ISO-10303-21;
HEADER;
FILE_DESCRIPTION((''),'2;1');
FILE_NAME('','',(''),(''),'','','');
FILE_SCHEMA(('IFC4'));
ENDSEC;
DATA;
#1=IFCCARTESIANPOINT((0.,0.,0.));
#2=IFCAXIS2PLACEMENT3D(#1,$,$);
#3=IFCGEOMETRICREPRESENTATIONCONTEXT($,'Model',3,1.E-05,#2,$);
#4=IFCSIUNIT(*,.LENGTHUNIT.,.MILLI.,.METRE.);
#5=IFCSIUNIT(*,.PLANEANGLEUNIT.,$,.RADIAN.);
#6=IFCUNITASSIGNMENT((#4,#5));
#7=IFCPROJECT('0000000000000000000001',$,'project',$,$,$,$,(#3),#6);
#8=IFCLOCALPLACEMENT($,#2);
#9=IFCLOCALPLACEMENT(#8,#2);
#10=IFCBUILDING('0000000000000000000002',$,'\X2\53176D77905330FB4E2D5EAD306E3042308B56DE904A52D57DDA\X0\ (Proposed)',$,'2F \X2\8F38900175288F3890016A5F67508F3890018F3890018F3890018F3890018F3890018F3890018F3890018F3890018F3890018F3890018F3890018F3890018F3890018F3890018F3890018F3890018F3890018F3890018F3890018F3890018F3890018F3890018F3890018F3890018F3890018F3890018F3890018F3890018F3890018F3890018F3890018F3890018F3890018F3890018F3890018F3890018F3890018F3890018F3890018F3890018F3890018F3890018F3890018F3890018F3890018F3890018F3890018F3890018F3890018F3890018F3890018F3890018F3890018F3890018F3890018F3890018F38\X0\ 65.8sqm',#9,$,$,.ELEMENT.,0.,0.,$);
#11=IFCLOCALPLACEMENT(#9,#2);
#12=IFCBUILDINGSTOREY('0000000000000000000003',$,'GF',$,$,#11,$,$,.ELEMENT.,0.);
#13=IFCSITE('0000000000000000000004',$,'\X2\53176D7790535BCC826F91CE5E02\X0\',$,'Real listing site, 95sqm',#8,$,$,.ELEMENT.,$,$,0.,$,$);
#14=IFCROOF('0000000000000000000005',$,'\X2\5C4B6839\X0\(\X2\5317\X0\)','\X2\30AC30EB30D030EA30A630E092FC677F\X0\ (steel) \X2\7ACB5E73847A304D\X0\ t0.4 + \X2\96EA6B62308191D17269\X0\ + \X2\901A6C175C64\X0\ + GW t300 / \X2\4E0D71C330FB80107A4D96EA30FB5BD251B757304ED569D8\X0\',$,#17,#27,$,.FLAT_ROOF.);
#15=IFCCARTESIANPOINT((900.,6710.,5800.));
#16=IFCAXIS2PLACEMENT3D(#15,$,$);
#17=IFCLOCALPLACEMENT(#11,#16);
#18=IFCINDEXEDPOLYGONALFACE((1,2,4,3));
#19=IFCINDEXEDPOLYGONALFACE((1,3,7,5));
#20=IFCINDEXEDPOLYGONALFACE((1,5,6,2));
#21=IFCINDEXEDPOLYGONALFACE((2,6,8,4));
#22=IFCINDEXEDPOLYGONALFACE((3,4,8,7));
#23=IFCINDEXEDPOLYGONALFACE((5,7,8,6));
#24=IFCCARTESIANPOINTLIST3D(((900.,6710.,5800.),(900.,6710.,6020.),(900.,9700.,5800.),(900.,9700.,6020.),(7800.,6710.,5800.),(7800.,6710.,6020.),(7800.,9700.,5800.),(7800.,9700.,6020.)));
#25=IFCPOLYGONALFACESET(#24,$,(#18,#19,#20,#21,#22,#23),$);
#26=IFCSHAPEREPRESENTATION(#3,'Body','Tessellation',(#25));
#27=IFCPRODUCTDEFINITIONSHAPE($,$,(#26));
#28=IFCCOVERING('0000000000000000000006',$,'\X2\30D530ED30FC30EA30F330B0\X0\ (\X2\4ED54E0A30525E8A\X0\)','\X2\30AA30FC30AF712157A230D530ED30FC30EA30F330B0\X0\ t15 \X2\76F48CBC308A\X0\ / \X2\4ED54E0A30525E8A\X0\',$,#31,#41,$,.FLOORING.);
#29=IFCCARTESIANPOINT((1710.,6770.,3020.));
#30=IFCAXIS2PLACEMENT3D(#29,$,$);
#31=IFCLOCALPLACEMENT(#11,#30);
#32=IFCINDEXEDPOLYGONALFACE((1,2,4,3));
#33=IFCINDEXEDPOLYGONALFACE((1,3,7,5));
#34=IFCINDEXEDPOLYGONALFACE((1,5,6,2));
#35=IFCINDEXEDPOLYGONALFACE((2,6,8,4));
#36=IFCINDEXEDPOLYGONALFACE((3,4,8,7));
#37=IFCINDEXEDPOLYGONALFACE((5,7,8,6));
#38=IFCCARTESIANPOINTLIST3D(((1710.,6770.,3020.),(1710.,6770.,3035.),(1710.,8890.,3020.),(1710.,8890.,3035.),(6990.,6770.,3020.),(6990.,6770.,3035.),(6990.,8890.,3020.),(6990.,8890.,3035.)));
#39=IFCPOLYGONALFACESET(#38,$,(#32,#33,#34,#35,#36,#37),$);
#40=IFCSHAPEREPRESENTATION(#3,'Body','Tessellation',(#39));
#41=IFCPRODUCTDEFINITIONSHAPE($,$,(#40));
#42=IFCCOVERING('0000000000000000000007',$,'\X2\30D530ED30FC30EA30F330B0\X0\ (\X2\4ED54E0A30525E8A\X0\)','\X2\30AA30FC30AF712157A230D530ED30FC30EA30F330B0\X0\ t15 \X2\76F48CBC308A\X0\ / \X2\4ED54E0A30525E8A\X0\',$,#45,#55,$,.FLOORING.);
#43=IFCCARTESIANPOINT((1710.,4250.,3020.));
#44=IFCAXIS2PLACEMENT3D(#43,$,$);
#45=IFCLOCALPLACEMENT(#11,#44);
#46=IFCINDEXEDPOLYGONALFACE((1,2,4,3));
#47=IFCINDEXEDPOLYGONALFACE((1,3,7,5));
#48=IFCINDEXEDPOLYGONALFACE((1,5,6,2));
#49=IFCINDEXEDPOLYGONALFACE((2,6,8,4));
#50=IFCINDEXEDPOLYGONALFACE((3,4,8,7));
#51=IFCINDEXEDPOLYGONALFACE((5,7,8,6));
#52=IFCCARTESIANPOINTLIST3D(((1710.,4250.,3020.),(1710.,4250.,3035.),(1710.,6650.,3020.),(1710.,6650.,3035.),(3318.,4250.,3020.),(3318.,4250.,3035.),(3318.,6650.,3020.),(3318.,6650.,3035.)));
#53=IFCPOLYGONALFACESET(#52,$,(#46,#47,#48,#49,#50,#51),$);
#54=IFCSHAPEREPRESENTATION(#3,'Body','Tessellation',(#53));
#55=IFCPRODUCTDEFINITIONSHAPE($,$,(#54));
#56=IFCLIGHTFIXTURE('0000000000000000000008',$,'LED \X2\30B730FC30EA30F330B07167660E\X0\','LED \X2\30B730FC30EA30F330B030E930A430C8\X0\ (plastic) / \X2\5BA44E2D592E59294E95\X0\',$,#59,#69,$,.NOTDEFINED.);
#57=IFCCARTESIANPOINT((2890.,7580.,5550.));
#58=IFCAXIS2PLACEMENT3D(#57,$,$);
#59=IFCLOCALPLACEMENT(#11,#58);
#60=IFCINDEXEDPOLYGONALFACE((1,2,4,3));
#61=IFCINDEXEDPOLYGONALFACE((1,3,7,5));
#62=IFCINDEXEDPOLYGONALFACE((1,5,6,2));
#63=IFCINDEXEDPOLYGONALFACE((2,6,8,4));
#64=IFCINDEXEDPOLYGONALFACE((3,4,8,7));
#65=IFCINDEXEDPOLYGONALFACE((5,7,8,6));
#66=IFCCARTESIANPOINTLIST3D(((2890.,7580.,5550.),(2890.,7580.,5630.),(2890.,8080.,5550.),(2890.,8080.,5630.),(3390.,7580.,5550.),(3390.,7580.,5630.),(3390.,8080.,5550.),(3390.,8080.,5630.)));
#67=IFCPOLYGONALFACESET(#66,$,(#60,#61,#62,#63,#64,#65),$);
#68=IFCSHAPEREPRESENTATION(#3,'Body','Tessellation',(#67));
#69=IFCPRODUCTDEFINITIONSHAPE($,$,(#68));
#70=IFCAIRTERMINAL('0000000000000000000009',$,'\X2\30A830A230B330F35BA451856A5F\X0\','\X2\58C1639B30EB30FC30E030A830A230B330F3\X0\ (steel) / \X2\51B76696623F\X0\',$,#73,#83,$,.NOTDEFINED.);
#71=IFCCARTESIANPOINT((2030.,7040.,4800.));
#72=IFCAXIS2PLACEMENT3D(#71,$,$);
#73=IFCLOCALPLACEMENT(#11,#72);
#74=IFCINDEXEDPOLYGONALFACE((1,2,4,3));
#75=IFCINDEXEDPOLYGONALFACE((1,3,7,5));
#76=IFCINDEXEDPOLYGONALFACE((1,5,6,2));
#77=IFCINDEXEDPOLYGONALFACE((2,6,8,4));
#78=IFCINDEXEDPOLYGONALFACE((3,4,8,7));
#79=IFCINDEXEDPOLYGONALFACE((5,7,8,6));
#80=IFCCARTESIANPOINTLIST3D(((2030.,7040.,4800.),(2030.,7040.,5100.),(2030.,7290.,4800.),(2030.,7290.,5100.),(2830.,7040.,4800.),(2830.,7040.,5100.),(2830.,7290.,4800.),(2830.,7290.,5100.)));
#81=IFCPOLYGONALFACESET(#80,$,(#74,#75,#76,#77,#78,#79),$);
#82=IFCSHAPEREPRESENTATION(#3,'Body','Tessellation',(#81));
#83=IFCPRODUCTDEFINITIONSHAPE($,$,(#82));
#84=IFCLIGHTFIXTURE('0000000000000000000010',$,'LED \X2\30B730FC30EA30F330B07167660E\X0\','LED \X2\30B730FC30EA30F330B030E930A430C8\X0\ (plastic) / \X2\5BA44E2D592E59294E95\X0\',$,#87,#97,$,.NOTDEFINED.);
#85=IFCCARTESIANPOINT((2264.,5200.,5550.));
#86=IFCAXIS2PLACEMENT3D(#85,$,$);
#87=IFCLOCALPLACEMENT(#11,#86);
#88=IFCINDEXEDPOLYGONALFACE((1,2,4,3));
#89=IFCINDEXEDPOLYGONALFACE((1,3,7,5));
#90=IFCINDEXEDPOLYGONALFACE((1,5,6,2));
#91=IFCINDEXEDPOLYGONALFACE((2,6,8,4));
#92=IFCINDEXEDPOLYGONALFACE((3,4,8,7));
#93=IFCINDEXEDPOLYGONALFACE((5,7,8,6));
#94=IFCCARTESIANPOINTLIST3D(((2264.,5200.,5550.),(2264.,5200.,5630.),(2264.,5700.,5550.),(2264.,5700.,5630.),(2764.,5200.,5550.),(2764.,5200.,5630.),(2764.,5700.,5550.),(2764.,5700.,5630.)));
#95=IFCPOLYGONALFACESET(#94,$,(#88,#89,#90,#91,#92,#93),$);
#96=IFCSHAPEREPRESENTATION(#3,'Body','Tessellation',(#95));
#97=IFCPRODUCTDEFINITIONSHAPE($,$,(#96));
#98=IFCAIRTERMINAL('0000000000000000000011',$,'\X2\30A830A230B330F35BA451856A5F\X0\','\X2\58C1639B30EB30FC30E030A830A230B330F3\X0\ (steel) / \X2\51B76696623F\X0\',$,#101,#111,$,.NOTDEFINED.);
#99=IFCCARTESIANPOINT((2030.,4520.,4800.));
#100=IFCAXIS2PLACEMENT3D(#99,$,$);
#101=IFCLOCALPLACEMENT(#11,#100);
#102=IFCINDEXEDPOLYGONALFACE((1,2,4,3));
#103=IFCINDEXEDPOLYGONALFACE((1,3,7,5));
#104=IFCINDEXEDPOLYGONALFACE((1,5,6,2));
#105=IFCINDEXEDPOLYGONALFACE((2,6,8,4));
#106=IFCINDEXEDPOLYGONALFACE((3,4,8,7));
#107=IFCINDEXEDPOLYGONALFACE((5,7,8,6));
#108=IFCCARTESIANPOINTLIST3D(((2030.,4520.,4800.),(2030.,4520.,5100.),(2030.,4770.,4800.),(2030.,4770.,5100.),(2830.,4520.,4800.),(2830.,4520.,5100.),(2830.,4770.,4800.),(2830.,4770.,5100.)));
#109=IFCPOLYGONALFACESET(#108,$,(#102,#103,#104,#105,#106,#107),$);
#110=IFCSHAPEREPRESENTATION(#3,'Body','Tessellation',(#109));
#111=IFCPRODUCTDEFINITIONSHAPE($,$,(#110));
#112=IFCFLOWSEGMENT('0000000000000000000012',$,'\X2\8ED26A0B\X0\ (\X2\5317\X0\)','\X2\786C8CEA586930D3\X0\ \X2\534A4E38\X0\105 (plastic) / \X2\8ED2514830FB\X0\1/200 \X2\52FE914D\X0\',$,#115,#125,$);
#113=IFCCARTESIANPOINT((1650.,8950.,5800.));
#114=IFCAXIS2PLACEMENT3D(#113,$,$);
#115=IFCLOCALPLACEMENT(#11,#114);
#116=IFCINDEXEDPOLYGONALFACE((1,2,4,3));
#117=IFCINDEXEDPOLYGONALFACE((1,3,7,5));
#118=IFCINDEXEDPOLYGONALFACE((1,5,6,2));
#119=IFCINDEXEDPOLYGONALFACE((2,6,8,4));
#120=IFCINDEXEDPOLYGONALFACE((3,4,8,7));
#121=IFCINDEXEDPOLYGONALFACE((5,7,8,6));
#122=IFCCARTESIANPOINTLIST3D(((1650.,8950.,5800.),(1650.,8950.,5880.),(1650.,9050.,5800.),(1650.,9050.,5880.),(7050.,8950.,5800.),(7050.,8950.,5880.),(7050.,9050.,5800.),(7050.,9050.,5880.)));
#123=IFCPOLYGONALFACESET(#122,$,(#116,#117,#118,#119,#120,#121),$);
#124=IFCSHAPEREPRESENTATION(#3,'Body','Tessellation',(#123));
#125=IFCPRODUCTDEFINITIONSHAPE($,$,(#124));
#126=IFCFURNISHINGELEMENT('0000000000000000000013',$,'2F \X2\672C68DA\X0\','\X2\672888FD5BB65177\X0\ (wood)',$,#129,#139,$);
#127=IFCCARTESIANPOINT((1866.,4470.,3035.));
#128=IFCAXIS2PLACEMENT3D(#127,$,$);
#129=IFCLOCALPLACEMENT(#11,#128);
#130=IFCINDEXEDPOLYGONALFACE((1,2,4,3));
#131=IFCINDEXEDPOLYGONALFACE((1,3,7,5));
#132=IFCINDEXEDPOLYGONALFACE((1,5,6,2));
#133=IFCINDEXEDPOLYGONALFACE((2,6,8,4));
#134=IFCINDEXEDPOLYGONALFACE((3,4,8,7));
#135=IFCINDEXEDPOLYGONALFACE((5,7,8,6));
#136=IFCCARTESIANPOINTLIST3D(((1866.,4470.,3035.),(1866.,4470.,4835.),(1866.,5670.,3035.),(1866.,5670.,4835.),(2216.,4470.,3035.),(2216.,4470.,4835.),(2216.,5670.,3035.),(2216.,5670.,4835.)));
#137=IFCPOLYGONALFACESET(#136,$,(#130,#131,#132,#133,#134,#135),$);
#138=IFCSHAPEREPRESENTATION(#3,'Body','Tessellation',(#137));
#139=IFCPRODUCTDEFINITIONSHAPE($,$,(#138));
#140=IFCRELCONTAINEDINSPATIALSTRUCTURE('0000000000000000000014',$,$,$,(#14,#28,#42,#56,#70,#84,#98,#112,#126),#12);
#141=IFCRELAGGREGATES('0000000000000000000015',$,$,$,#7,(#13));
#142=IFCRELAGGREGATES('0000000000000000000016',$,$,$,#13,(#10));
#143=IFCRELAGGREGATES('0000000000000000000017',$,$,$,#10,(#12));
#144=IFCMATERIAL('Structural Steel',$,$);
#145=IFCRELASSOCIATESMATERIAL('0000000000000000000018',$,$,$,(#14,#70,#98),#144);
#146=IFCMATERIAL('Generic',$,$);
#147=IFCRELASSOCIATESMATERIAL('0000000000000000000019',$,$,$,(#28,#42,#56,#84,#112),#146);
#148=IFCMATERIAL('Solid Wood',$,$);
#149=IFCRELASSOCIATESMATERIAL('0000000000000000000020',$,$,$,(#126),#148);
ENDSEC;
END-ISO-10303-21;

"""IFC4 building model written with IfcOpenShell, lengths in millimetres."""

from ifc_helpers import new_model, si_unit, frame, frame_2d, origin, place, context, project, spatial, rectangle, extrude, material, element, save


model = new_model("IFC4")

# Units and contexts
model_context = context("Model", 3, precision=1e-05, world=origin())
ifc_project = project(units=[si_unit("LENGTHUNIT", "METRE", prefix="MILLI"), si_unit("PLANEANGLEUNIT", "RADIAN")], contexts=[model_context])

# Site, building, storey
site_placement = place(None, origin())
site = spatial("IfcSite", under=ifc_project, at=site_placement, Name="北海道富良野市", ObjectType="Real listing site, 95sqm", CompositionType="ELEMENT", RefElevation=0.0)
building_placement = place(site_placement, origin())
building = spatial("IfcBuilding", under=site, at=building_placement, Name="北海道・中庭のある回遊動線 (Proposed)", ObjectType="2F 輸送用輸送機材輸送輸送輸送輸送輸送輸送輸送輸送輸送輸送輸送輸送輸送輸送輸送輸送輸送輸送輸送輸送輸送輸送輸送輸送輸送輸送輸送輸送輸送輸送輸送輸送輸送輸送輸送輸送輸送輸送輸送輸送輸送輸送輸送輸送輸送輸送輸送輸送輸送輸送輸送輸送輸送輸送輸送輸送輸 65.8sqm", CompositionType="ELEMENT", ElevationOfRefHeight=0.0, ElevationOfTerrain=0.0)
storey_placement = place(building_placement, origin())
storey = spatial("IfcBuildingStorey", under=building, at=storey_placement, Name="GF", CompositionType="ELEMENT", Elevation=0.0)

# Shared definitions
ifc_material_1 = material(Name="Solid Wood")

# Roof
ifc_material_2 = material(Name="Structural Steel")
for number, where, name in (
    (1, (900.0, 6710.0, 5800.0), "屋根(北)"),
):
    element("IfcRoof", number, at=place(storey_placement, frame(where)), inside=storey, material=ifc_material_2, Name=name, Description="ガルバリウム鋼板 (steel) 立平葺き t0.4 + 雪止め金物 + 通気層 + GW t300 / 不燃・耐積雪・寒冷地仕様", PredefinedType="FLAT_ROOF", context=model_context, shape_type="SweptSolid", body=[
        extrude(rectangle(XDim=6900.0, YDim=2990.0, at=frame_2d((3450.0, 1495.0))), frame((900.0, 6710.0, 5800.0)), (0.0, 0.0, 1.0), 220.0),
    ])

# Coverings
ifc_material_3 = material(Name="Generic")
covering_1_placement = place(storey_placement, frame((1710.0, 6770.0, 3020.0)))
element("IfcCovering", 2, at=covering_1_placement, inside=storey, material=ifc_material_3, Name="フローリング (仕上げ床)", Description="オーク無垢フローリング t15 直貼り / 仕上げ床", PredefinedType="FLOORING", context=model_context, shape_type="SweptSolid", body=[
    extrude(rectangle(XDim=5280.0, YDim=2120.0, at=frame_2d((2640.0, 1060.0))), frame((1710.0, 6770.0, 3020.0)), (0.0, 0.0, 1.0), 15.0),
])
covering_2_placement = place(storey_placement, frame((1710.0, 4250.0, 3020.0)))
element("IfcCovering", 3, at=covering_2_placement, inside=storey, material=ifc_material_3, Name="フローリング (仕上げ床)", Description="オーク無垢フローリング t15 直貼り / 仕上げ床", PredefinedType="FLOORING", context=model_context, shape_type="SweptSolid", body=[
    extrude(rectangle(XDim=1608.0, YDim=2400.0, at=frame_2d((804.0, 1200.0))), frame((1710.0, 4250.0, 3020.0)), (0.0, 0.0, 1.0), 15.0),
])

# Light fixture
light_fixture_1_placement = place(storey_placement, frame((2890.0, 7580.0, 5550.0)))
element("IfcLightFixture", 4, at=light_fixture_1_placement, inside=storey, material=ifc_material_3, Name="LED シーリング照明", Description="LED シーリングライト (plastic) / 室中央天井", PredefinedType="NOTDEFINED", context=model_context, shape_type="SweptSolid", body=[
    extrude(rectangle(XDim=500.0, YDim=500.0, at=frame_2d((250.0, 250.0))), frame((2890.0, 7580.0, 5550.0)), (0.0, 0.0, 1.0), 80.0),
])

# Air terminal
air_terminal_1_placement = place(storey_placement, frame((2030.0, 7040.0, 4800.0)))
element("IfcAirTerminal", 5, at=air_terminal_1_placement, inside=storey, material=ifc_material_2, Name="エアコン室内機", Description="壁掛ルームエアコン (steel) / 冷暖房", PredefinedType="NOTDEFINED", context=model_context, shape_type="SweptSolid", body=[
    extrude(rectangle(XDim=800.0, YDim=250.0, at=frame_2d((400.0, 125.0))), frame((2030.0, 7040.0, 4800.0)), (0.0, 0.0, 1.0), 300.0),
])

# Light fixture
light_fixture_2_placement = place(storey_placement, frame((2264.0, 5200.0, 5550.0)))
element("IfcLightFixture", 6, at=light_fixture_2_placement, inside=storey, material=ifc_material_3, Name="LED シーリング照明", Description="LED シーリングライト (plastic) / 室中央天井", PredefinedType="NOTDEFINED", context=model_context, shape_type="SweptSolid", body=[
    extrude(rectangle(XDim=500.0, YDim=500.0, at=frame_2d((250.0, 250.0))), frame((2264.0, 5200.0, 5550.0)), (0.0, 0.0, 1.0), 80.0),
])

# Air terminal
air_terminal_2_placement = place(storey_placement, frame((2030.0, 4520.0, 4800.0)))
element("IfcAirTerminal", 7, at=air_terminal_2_placement, inside=storey, material=ifc_material_2, Name="エアコン室内機", Description="壁掛ルームエアコン (steel) / 冷暖房", PredefinedType="NOTDEFINED", context=model_context, shape_type="SweptSolid", body=[
    extrude(rectangle(XDim=800.0, YDim=250.0, at=frame_2d((400.0, 125.0))), frame((2030.0, 4520.0, 4800.0)), (0.0, 0.0, 1.0), 300.0),
])

# Flow segment
flow_segment_placement = place(storey_placement, frame((1650.0, 8950.0, 5800.0)))
element("IfcFlowSegment", 8, at=flow_segment_placement, inside=storey, material=ifc_material_3, Name="軒樋 (北)", Description="硬質塩ビ 半丸105 (plastic) / 軒先・1/200 勾配", context=model_context, shape_type="SweptSolid", body=[
    extrude(rectangle(XDim=5400.0, YDim=100.0, at=frame_2d((2700.0, 50.0))), frame((1650.0, 8950.0, 5800.0)), (0.0, 0.0, 1.0), 80.0),
])

# Furnishing element
furnishing_placement = place(storey_placement, frame((1866.0, 4470.0, 3035.0)))
element("IfcFurnishingElement", 9, at=furnishing_placement, inside=storey, material=ifc_material_1, Name="2F 本棚", Description="木製家具 (wood)", context=model_context, shape_type="SweptSolid", body=[
    extrude(rectangle(XDim=350.0, YDim=1200.0, at=frame_2d((175.0, 600.0))), frame((1866.0, 4470.0, 3035.0)), (0.0, 0.0, 1.0), 1800.0),
])

save(model, "model.ifc")
